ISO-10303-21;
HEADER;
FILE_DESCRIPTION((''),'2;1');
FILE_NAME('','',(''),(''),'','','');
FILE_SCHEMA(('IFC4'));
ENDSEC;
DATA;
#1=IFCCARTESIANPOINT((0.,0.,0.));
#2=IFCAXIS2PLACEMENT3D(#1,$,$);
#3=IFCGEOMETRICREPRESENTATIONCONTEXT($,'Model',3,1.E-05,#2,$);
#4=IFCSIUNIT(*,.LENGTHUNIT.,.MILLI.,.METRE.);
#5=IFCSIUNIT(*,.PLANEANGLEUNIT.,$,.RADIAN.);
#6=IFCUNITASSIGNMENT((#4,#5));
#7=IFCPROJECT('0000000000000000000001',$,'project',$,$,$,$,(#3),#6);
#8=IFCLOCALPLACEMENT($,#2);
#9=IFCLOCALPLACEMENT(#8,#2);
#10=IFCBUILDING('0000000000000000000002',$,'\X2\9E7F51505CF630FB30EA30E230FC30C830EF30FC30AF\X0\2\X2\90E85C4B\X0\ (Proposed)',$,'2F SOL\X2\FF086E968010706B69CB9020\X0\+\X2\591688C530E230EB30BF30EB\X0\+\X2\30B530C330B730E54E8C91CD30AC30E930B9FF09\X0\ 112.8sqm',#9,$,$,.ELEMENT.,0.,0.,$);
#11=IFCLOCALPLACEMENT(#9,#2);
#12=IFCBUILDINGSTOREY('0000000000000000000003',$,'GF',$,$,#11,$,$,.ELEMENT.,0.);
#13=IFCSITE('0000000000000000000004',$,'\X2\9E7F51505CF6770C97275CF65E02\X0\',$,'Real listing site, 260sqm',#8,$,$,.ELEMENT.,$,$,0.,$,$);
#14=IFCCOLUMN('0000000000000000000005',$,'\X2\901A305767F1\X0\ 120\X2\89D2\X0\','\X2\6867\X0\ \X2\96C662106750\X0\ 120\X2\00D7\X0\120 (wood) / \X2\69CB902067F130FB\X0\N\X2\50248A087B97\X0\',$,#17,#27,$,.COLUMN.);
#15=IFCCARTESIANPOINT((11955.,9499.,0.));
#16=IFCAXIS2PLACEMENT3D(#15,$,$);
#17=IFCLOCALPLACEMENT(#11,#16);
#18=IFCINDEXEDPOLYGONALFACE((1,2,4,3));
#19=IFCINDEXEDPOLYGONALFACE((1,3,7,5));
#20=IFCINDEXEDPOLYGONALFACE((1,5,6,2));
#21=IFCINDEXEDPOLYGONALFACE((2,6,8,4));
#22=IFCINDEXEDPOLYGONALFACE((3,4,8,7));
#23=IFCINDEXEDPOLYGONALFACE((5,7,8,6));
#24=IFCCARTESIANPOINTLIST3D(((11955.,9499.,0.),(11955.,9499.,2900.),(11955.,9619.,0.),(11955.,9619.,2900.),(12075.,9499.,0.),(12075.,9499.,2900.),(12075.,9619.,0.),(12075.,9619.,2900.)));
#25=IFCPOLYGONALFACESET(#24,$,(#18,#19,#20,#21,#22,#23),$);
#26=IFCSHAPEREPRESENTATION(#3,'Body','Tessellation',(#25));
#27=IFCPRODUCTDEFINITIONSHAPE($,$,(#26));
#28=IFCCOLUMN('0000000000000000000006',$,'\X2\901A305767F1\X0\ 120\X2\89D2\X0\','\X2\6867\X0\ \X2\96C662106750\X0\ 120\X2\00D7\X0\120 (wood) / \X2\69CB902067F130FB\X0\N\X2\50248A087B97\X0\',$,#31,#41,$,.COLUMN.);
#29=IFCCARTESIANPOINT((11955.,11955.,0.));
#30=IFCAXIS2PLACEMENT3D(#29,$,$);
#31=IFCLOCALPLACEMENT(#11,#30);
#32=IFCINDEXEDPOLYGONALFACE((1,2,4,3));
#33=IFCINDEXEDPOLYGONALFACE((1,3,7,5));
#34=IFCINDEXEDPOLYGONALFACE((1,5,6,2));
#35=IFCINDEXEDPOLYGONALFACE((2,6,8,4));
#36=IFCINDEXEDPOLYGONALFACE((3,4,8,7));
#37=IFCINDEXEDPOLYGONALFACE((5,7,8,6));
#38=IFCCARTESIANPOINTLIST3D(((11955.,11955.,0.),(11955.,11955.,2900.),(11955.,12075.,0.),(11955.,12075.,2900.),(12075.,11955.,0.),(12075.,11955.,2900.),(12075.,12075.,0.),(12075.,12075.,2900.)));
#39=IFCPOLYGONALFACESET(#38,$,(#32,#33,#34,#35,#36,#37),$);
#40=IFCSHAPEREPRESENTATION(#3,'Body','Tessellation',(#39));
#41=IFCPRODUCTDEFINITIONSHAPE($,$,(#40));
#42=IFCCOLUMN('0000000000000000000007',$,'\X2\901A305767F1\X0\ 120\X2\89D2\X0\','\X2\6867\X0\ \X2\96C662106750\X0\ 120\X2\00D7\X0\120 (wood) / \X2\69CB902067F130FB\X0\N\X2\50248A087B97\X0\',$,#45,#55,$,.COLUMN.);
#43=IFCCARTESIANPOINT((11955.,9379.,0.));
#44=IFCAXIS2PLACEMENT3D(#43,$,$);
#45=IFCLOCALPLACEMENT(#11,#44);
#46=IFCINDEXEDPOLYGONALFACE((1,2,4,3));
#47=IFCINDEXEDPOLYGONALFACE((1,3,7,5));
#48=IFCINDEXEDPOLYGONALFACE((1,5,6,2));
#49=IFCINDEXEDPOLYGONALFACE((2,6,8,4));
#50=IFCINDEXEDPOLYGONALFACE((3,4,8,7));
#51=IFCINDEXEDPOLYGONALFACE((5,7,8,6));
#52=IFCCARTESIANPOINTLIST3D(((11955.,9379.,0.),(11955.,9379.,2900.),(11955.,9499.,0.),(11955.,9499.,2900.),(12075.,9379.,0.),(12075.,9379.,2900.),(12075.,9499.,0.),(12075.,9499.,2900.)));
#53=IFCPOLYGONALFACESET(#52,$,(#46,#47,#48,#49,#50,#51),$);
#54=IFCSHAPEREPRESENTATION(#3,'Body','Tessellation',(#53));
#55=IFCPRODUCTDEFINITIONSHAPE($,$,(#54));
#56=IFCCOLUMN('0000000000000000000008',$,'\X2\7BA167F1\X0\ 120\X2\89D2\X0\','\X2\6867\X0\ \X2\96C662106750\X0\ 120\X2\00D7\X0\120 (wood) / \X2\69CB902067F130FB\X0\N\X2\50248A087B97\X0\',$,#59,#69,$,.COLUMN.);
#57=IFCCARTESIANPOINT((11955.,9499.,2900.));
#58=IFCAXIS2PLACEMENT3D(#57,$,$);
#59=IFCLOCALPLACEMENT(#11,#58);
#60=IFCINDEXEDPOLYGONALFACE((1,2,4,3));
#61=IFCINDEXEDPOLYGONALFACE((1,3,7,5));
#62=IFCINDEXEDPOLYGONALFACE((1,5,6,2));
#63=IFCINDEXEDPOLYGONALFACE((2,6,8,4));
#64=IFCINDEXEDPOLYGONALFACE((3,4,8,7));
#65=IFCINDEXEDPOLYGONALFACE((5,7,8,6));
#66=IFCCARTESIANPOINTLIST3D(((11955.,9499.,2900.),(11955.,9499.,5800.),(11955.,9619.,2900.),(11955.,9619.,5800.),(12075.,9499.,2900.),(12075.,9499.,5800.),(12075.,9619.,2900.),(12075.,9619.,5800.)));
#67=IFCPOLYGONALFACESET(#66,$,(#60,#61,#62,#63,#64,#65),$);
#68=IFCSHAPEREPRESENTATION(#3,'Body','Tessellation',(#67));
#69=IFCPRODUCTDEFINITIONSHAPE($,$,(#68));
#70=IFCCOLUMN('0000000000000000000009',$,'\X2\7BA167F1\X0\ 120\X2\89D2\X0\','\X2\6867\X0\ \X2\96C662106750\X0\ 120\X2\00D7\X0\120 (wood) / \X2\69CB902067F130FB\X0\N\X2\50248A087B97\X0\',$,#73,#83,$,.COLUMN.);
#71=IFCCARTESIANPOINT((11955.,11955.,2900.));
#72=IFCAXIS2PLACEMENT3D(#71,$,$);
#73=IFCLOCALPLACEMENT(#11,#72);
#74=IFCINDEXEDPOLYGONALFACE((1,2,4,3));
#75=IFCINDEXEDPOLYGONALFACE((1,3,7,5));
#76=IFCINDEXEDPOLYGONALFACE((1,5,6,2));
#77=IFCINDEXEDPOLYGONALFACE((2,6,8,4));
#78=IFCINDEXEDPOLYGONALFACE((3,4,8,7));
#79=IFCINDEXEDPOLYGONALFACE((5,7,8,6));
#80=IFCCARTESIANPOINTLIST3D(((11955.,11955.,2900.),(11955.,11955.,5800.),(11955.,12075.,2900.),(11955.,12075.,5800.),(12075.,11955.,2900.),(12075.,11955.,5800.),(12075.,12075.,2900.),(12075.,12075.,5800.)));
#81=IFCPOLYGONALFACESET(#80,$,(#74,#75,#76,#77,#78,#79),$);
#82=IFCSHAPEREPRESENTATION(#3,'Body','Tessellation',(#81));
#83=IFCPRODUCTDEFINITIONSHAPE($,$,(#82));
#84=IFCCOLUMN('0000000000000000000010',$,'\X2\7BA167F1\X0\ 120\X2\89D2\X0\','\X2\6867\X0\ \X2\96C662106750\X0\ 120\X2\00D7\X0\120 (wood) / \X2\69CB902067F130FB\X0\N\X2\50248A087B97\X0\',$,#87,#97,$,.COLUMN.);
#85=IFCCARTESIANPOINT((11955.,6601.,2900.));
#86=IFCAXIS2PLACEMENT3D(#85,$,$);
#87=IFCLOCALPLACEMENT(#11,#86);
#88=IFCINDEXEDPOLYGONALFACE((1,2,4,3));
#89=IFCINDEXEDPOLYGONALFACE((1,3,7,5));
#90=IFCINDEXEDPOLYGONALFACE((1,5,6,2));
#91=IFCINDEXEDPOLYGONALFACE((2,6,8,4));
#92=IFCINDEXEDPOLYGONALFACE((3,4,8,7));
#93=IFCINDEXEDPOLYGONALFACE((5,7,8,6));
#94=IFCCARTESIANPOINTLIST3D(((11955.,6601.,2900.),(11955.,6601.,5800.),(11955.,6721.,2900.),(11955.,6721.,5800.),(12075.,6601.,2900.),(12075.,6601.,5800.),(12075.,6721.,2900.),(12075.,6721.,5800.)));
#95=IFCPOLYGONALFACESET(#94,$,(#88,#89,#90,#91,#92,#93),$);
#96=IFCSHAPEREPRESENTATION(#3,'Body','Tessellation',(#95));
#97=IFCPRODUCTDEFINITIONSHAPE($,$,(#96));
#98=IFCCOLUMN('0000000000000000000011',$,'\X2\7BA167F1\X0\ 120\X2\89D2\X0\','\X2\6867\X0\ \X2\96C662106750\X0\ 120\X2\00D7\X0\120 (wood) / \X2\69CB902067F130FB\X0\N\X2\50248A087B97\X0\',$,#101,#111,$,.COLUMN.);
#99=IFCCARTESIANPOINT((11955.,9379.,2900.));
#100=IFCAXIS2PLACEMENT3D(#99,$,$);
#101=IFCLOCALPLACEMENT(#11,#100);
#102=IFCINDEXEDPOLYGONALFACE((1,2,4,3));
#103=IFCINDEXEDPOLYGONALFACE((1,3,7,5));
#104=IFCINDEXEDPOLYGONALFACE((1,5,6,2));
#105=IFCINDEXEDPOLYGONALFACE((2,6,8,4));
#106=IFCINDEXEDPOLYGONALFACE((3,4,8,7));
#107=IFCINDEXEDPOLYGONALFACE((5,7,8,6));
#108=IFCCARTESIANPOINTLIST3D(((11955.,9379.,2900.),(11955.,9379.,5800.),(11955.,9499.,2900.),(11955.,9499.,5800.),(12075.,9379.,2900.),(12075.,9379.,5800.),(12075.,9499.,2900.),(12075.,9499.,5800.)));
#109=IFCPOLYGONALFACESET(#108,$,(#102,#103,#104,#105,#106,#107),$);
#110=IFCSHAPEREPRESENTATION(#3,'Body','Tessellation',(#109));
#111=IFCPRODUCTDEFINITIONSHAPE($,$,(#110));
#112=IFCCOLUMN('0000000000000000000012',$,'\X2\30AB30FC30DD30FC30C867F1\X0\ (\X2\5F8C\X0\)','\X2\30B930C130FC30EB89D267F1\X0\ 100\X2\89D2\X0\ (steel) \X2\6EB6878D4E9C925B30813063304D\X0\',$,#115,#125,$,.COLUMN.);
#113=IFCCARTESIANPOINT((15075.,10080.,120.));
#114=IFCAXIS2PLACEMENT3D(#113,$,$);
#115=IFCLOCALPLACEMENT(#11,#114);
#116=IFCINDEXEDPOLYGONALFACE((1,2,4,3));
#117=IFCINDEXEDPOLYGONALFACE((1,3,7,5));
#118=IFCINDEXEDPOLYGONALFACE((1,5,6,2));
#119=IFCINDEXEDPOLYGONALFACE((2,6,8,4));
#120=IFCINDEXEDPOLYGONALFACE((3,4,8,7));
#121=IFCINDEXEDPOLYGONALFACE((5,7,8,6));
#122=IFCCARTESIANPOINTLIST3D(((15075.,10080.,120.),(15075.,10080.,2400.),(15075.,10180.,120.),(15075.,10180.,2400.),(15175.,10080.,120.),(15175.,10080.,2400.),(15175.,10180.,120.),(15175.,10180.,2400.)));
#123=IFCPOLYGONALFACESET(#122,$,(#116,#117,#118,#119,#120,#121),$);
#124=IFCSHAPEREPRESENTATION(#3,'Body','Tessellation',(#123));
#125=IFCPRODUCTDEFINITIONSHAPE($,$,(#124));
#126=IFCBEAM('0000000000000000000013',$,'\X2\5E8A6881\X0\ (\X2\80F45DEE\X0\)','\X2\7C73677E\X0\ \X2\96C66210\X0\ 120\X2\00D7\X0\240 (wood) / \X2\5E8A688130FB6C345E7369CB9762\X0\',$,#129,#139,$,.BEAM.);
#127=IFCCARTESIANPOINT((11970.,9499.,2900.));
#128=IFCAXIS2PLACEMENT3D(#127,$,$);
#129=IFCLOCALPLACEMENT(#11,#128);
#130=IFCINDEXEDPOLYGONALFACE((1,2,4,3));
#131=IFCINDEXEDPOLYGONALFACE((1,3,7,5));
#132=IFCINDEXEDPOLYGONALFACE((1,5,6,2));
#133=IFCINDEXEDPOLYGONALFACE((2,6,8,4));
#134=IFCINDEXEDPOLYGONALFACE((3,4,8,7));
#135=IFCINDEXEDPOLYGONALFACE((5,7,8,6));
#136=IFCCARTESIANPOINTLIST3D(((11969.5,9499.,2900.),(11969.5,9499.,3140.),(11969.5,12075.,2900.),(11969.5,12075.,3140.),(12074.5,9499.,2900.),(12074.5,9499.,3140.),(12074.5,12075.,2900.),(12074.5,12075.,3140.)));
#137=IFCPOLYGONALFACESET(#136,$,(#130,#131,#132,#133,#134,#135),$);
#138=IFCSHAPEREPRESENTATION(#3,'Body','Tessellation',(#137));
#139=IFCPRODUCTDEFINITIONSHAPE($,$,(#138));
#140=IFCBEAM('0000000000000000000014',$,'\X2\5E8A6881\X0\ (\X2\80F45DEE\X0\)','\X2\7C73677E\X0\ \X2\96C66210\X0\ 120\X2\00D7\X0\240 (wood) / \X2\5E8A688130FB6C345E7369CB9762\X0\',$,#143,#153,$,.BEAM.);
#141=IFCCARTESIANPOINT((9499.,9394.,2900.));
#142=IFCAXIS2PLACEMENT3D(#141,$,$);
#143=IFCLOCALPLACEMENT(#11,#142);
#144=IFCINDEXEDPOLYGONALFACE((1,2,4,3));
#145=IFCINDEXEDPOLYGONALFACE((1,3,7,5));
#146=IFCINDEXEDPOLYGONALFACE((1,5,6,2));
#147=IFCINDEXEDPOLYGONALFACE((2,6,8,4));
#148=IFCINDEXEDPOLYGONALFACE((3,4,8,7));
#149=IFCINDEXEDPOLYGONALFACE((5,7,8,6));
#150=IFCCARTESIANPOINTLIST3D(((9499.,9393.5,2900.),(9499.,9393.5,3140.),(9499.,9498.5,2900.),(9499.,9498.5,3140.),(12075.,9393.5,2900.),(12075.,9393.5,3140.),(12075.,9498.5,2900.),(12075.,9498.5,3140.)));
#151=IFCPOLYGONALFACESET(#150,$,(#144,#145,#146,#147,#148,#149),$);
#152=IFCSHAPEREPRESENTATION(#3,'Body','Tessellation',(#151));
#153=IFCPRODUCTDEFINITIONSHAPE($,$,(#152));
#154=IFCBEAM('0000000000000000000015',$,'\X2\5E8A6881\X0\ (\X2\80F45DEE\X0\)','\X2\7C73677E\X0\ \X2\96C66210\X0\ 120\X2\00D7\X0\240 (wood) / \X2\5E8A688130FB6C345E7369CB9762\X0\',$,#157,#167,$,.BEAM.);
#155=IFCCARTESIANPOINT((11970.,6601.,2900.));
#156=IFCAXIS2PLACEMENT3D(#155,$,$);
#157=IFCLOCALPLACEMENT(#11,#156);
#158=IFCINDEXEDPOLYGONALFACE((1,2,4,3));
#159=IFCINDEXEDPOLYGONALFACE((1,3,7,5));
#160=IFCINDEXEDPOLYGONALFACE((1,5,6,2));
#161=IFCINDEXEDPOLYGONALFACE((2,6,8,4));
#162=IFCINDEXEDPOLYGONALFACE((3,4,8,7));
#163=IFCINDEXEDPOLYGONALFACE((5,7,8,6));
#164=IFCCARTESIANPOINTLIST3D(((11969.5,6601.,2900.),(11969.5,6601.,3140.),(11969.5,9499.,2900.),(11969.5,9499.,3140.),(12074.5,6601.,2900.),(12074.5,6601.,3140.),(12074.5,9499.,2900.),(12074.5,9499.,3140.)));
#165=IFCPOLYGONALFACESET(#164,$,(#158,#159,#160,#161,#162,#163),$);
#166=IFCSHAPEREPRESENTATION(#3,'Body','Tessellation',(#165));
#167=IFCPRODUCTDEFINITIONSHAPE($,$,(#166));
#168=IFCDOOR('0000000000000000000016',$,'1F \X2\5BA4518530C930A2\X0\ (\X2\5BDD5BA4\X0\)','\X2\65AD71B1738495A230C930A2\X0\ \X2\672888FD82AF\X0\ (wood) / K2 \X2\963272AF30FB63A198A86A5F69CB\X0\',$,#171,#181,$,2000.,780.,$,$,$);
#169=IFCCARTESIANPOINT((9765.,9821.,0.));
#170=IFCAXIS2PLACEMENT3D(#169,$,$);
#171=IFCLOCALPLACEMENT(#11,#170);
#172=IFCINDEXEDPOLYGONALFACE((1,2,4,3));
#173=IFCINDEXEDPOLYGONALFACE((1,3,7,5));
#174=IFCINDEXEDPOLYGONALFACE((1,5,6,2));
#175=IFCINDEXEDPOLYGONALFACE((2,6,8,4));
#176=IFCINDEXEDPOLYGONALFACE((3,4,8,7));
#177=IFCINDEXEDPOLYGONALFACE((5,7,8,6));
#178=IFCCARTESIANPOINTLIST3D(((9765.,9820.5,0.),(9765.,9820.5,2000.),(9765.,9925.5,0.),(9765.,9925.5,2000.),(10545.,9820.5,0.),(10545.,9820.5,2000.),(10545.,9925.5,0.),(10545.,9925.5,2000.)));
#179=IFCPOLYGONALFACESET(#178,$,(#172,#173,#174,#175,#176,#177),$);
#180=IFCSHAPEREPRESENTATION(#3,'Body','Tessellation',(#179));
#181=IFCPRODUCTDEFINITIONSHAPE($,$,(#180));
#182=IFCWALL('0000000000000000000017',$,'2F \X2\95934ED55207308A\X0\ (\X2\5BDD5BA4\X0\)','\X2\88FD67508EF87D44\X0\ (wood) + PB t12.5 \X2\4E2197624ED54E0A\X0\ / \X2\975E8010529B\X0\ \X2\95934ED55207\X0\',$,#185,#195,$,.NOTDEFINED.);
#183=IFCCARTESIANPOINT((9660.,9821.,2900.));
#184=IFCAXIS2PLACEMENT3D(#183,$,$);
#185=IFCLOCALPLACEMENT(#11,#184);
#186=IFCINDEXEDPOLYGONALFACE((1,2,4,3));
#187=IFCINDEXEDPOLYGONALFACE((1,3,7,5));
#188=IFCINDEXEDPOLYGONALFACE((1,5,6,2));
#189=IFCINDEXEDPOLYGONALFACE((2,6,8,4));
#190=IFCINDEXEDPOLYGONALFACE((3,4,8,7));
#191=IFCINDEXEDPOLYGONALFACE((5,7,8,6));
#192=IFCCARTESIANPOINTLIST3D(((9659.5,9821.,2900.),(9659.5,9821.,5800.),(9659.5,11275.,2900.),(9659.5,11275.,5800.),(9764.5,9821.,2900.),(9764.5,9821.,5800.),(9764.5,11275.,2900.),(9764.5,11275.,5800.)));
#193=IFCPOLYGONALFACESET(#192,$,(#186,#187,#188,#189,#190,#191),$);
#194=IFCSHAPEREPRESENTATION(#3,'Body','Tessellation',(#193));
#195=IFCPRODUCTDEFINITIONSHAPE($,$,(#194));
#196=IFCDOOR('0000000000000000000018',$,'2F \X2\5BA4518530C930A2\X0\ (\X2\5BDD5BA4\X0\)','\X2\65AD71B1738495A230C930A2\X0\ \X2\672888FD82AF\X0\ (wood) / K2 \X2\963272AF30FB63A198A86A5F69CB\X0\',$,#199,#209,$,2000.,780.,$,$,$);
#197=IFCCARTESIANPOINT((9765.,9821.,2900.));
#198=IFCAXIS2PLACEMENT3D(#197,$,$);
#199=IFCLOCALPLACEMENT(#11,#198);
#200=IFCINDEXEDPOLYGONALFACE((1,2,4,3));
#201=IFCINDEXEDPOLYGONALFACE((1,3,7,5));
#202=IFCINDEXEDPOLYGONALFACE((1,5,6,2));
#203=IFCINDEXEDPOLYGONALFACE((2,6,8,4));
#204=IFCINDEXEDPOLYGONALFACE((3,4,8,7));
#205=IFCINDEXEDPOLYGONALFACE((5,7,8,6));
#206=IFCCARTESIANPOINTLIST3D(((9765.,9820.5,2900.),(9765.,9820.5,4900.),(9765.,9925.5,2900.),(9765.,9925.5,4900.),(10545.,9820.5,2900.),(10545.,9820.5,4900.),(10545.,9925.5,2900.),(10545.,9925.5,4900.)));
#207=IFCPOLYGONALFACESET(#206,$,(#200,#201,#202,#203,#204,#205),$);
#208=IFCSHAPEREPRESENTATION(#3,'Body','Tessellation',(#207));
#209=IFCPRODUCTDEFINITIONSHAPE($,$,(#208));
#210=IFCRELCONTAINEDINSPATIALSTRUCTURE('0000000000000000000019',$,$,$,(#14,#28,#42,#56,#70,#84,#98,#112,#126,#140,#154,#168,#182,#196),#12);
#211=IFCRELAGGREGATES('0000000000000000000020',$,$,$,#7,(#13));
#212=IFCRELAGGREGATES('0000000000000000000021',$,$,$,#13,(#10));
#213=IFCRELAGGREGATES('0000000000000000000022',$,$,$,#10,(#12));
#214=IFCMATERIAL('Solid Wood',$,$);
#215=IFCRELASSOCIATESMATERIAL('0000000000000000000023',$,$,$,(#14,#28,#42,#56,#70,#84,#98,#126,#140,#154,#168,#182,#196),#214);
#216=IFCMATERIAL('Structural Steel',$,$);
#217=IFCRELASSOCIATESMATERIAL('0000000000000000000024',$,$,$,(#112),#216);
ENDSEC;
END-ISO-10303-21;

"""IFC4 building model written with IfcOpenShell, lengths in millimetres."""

from ifc_helpers import new_model, si_unit, frame, frame_2d, origin, place, context, project, spatial, rectangle, extrude, material, element, save


model = new_model("IFC4")

# Units and contexts
model_context = context("Model", 3, precision=1e-05, world=origin())
ifc_project = project(units=[si_unit("LENGTHUNIT", "METRE", prefix="MILLI"), si_unit("PLANEANGLEUNIT", "RADIAN")], contexts=[model_context])

# Site, building, storey
site_placement = place(None, origin())
site = spatial("IfcSite", under=ifc_project, at=site_placement, Name="鹿児島県霧島市", ObjectType="Real listing site, 260sqm", CompositionType="ELEMENT", RefElevation=0.0)
building_placement = place(site_placement, origin())
building = spatial("IfcBuilding", under=site, at=building_placement, Name="鹿児島・リモートワーク2部屋 (Proposed)", ObjectType="2F SOL（準耐火構造+外装モルタル+サッシュ二重ガラス） 112.8sqm", CompositionType="ELEMENT", ElevationOfRefHeight=0.0, ElevationOfTerrain=0.0)
storey_placement = place(building_placement, origin())
storey = spatial("IfcBuildingStorey", under=building, at=storey_placement, Name="GF", CompositionType="ELEMENT", Elevation=0.0)

# Columns
ifc_material_1 = material(Name="Solid Wood")
column_1_placement = place(storey_placement, frame((11955.0, 9499.0, 0.0)))
element("IfcColumn", 1, at=column_1_placement, inside=storey, material=ifc_material_1, Name="通し柱 120角", Description="桧 集成材 120×120 (wood) / 構造柱・N値計算", PredefinedType="COLUMN", context=model_context, shape_type="SweptSolid", body=[
    extrude(rectangle(XDim=120.0, YDim=120.0, at=frame_2d((60.0, 60.0))), frame((11955.0, 9499.0, 0.0)), (0.0, 0.0, 1.0), 2900.0),
])
column_2_placement = place(storey_placement, frame((11955.0, 11955.0, 0.0)))
element("IfcColumn", 2, at=column_2_placement, inside=storey, material=ifc_material_1, Name="通し柱 120角", Description="桧 集成材 120×120 (wood) / 構造柱・N値計算", PredefinedType="COLUMN", context=model_context, shape_type="SweptSolid", body=[
    extrude(rectangle(XDim=120.0, YDim=120.0, at=frame_2d((60.0, 60.0))), frame((11955.0, 11955.0, 0.0)), (0.0, 0.0, 1.0), 2900.0),
])
column_3_placement = place(storey_placement, frame((11955.0, 9379.0, 0.0)))
element("IfcColumn", 3, at=column_3_placement, inside=storey, material=ifc_material_1, Name="通し柱 120角", Description="桧 集成材 120×120 (wood) / 構造柱・N値計算", PredefinedType="COLUMN", context=model_context, shape_type="SweptSolid", body=[
    extrude(rectangle(XDim=120.0, YDim=120.0, at=frame_2d((60.0, 60.0))), frame((11955.0, 9379.0, 0.0)), (0.0, 0.0, 1.0), 2900.0),
])
column_4_placement = place(storey_placement, frame((11955.0, 9499.0, 2900.0)))
element("IfcColumn", 4, at=column_4_placement, inside=storey, material=ifc_material_1, Name="管柱 120角", Description="桧 集成材 120×120 (wood) / 構造柱・N値計算", PredefinedType="COLUMN", context=model_context, shape_type="SweptSolid", body=[
    extrude(rectangle(XDim=120.0, YDim=120.0, at=frame_2d((60.0, 60.0))), frame((11955.0, 9499.0, 2900.0)), (0.0, 0.0, 1.0), 2900.0),
])
column_5_placement = place(storey_placement, frame((11955.0, 11955.0, 2900.0)))
element("IfcColumn", 5, at=column_5_placement, inside=storey, material=ifc_material_1, Name="管柱 120角", Description="桧 集成材 120×120 (wood) / 構造柱・N値計算", PredefinedType="COLUMN", context=model_context, shape_type="SweptSolid", body=[
    extrude(rectangle(XDim=120.0, YDim=120.0, at=frame_2d((60.0, 60.0))), frame((11955.0, 11955.0, 2900.0)), (0.0, 0.0, 1.0), 2900.0),
])
column_6_placement = place(storey_placement, frame((11955.0, 6601.0, 2900.0)))
element("IfcColumn", 6, at=column_6_placement, inside=storey, material=ifc_material_1, Name="管柱 120角", Description="桧 集成材 120×120 (wood) / 構造柱・N値計算", PredefinedType="COLUMN", context=model_context, shape_type="SweptSolid", body=[
    extrude(rectangle(XDim=120.0, YDim=120.0, at=frame_2d((60.0, 60.0))), frame((11955.0, 6601.0, 2900.0)), (0.0, 0.0, 1.0), 2900.0),
])
column_7_placement = place(storey_placement, frame((11955.0, 9379.0, 2900.0)))
element("IfcColumn", 7, at=column_7_placement, inside=storey, material=ifc_material_1, Name="管柱 120角", Description="桧 集成材 120×120 (wood) / 構造柱・N値計算", PredefinedType="COLUMN", context=model_context, shape_type="SweptSolid", body=[
    extrude(rectangle(XDim=120.0, YDim=120.0, at=frame_2d((60.0, 60.0))), frame((11955.0, 9379.0, 2900.0)), (0.0, 0.0, 1.0), 2900.0),
])
ifc_material_2 = material(Name="Structural Steel")
column_8_placement = place(storey_placement, frame((15075.0, 10080.0, 120.0)))
element("IfcColumn", 8, at=column_8_placement, inside=storey, material=ifc_material_2, Name="カーポート柱 (後)", Description="スチール角柱 100角 (steel) 溶融亜鉛めっき", PredefinedType="COLUMN", context=model_context, shape_type="SweptSolid", body=[
    extrude(rectangle(XDim=100.0, YDim=100.0, at=frame_2d((50.0, 50.0))), frame((15075.0, 10080.0, 120.0)), (0.0, 0.0, 1.0), 2280.0),
])

# Beams
beam_1_placement = place(storey_placement, frame((11970.0, 9499.0, 2900.0)))
element("IfcBeam", 9, at=beam_1_placement, inside=storey, material=ifc_material_1, Name="床梁 (胴差)", Description="米松 集成 120×240 (wood) / 床梁・水平構面", PredefinedType="BEAM", context=model_context, shape_type="SweptSolid", body=[
    extrude(rectangle(XDim=105.0, YDim=2576.0, at=frame_2d((52.0, 1288.0))), frame((11970.0, 9499.0, 2900.0)), (0.0, 0.0, 1.0), 240.0),
])
beam_2_placement = place(storey_placement, frame((9499.0, 9394.0, 2900.0)))
element("IfcBeam", 10, at=beam_2_placement, inside=storey, material=ifc_material_1, Name="床梁 (胴差)", Description="米松 集成 120×240 (wood) / 床梁・水平構面", PredefinedType="BEAM", context=model_context, shape_type="SweptSolid", body=[
    extrude(rectangle(XDim=2576.0, YDim=105.0, at=frame_2d((1288.0, 52.0))), frame((9499.0, 9394.0, 2900.0)), (0.0, 0.0, 1.0), 240.0),
])
beam_3_placement = place(storey_placement, frame((11970.0, 6601.0, 2900.0)))
element("IfcBeam", 11, at=beam_3_placement, inside=storey, material=ifc_material_1, Name="床梁 (胴差)", Description="米松 集成 120×240 (wood) / 床梁・水平構面", PredefinedType="BEAM", context=model_context, shape_type="SweptSolid", body=[
    extrude(rectangle(XDim=105.0, YDim=2898.0, at=frame_2d((52.0, 1449.0))), frame((11970.0, 6601.0, 2900.0)), (0.0, 0.0, 1.0), 240.0),
])

# Door
door_1_placement = place(storey_placement, frame((9765.0, 9821.0, 0.0)))
element("IfcDoor", 12, at=door_1_placement, inside=storey, material=ifc_material_1, Name="1F 室内ドア (寝室)", Description="断熱玄関ドア 木製芯 (wood) / K2 防犯・採風機構", OverallHeight=2000.0, OverallWidth=780.0, context=model_context, shape_type="SweptSolid", body=[
    extrude(rectangle(XDim=780.0, YDim=105.0, at=frame_2d((390.0, 52.0))), frame((9765.0, 9821.0, 0.0)), (0.0, 0.0, 1.0), 2000.0),
])

# Wall
wall_1_placement = place(storey_placement, frame((9660.0, 9821.0, 2900.0)))
element("IfcWall", 13, at=wall_1_placement, inside=storey, material=ifc_material_1, Name="2F 間仕切り (寝室)", Description="製材軸組 (wood) + PB t12.5 両面仕上 / 非耐力 間仕切", PredefinedType="NOTDEFINED", context=model_context, shape_type="SweptSolid", body=[
    extrude(rectangle(XDim=105.0, YDim=1454.0, at=frame_2d((52.0, 727.0))), frame((9660.0, 9821.0, 2900.0)), (0.0, 0.0, 1.0), 2900.0),
])

# Door
door_2_placement = place(storey_placement, frame((9765.0, 9821.0, 2900.0)))
element("IfcDoor", 14, at=door_2_placement, inside=storey, material=ifc_material_1, Name="2F 室内ドア (寝室)", Description="断熱玄関ドア 木製芯 (wood) / K2 防犯・採風機構", OverallHeight=2000.0, OverallWidth=780.0, context=model_context, shape_type="SweptSolid", body=[
    extrude(rectangle(XDim=780.0, YDim=105.0, at=frame_2d((390.0, 52.0))), frame((9765.0, 9821.0, 2900.0)), (0.0, 0.0, 1.0), 2000.0),
])

save(model, "model.ifc")
